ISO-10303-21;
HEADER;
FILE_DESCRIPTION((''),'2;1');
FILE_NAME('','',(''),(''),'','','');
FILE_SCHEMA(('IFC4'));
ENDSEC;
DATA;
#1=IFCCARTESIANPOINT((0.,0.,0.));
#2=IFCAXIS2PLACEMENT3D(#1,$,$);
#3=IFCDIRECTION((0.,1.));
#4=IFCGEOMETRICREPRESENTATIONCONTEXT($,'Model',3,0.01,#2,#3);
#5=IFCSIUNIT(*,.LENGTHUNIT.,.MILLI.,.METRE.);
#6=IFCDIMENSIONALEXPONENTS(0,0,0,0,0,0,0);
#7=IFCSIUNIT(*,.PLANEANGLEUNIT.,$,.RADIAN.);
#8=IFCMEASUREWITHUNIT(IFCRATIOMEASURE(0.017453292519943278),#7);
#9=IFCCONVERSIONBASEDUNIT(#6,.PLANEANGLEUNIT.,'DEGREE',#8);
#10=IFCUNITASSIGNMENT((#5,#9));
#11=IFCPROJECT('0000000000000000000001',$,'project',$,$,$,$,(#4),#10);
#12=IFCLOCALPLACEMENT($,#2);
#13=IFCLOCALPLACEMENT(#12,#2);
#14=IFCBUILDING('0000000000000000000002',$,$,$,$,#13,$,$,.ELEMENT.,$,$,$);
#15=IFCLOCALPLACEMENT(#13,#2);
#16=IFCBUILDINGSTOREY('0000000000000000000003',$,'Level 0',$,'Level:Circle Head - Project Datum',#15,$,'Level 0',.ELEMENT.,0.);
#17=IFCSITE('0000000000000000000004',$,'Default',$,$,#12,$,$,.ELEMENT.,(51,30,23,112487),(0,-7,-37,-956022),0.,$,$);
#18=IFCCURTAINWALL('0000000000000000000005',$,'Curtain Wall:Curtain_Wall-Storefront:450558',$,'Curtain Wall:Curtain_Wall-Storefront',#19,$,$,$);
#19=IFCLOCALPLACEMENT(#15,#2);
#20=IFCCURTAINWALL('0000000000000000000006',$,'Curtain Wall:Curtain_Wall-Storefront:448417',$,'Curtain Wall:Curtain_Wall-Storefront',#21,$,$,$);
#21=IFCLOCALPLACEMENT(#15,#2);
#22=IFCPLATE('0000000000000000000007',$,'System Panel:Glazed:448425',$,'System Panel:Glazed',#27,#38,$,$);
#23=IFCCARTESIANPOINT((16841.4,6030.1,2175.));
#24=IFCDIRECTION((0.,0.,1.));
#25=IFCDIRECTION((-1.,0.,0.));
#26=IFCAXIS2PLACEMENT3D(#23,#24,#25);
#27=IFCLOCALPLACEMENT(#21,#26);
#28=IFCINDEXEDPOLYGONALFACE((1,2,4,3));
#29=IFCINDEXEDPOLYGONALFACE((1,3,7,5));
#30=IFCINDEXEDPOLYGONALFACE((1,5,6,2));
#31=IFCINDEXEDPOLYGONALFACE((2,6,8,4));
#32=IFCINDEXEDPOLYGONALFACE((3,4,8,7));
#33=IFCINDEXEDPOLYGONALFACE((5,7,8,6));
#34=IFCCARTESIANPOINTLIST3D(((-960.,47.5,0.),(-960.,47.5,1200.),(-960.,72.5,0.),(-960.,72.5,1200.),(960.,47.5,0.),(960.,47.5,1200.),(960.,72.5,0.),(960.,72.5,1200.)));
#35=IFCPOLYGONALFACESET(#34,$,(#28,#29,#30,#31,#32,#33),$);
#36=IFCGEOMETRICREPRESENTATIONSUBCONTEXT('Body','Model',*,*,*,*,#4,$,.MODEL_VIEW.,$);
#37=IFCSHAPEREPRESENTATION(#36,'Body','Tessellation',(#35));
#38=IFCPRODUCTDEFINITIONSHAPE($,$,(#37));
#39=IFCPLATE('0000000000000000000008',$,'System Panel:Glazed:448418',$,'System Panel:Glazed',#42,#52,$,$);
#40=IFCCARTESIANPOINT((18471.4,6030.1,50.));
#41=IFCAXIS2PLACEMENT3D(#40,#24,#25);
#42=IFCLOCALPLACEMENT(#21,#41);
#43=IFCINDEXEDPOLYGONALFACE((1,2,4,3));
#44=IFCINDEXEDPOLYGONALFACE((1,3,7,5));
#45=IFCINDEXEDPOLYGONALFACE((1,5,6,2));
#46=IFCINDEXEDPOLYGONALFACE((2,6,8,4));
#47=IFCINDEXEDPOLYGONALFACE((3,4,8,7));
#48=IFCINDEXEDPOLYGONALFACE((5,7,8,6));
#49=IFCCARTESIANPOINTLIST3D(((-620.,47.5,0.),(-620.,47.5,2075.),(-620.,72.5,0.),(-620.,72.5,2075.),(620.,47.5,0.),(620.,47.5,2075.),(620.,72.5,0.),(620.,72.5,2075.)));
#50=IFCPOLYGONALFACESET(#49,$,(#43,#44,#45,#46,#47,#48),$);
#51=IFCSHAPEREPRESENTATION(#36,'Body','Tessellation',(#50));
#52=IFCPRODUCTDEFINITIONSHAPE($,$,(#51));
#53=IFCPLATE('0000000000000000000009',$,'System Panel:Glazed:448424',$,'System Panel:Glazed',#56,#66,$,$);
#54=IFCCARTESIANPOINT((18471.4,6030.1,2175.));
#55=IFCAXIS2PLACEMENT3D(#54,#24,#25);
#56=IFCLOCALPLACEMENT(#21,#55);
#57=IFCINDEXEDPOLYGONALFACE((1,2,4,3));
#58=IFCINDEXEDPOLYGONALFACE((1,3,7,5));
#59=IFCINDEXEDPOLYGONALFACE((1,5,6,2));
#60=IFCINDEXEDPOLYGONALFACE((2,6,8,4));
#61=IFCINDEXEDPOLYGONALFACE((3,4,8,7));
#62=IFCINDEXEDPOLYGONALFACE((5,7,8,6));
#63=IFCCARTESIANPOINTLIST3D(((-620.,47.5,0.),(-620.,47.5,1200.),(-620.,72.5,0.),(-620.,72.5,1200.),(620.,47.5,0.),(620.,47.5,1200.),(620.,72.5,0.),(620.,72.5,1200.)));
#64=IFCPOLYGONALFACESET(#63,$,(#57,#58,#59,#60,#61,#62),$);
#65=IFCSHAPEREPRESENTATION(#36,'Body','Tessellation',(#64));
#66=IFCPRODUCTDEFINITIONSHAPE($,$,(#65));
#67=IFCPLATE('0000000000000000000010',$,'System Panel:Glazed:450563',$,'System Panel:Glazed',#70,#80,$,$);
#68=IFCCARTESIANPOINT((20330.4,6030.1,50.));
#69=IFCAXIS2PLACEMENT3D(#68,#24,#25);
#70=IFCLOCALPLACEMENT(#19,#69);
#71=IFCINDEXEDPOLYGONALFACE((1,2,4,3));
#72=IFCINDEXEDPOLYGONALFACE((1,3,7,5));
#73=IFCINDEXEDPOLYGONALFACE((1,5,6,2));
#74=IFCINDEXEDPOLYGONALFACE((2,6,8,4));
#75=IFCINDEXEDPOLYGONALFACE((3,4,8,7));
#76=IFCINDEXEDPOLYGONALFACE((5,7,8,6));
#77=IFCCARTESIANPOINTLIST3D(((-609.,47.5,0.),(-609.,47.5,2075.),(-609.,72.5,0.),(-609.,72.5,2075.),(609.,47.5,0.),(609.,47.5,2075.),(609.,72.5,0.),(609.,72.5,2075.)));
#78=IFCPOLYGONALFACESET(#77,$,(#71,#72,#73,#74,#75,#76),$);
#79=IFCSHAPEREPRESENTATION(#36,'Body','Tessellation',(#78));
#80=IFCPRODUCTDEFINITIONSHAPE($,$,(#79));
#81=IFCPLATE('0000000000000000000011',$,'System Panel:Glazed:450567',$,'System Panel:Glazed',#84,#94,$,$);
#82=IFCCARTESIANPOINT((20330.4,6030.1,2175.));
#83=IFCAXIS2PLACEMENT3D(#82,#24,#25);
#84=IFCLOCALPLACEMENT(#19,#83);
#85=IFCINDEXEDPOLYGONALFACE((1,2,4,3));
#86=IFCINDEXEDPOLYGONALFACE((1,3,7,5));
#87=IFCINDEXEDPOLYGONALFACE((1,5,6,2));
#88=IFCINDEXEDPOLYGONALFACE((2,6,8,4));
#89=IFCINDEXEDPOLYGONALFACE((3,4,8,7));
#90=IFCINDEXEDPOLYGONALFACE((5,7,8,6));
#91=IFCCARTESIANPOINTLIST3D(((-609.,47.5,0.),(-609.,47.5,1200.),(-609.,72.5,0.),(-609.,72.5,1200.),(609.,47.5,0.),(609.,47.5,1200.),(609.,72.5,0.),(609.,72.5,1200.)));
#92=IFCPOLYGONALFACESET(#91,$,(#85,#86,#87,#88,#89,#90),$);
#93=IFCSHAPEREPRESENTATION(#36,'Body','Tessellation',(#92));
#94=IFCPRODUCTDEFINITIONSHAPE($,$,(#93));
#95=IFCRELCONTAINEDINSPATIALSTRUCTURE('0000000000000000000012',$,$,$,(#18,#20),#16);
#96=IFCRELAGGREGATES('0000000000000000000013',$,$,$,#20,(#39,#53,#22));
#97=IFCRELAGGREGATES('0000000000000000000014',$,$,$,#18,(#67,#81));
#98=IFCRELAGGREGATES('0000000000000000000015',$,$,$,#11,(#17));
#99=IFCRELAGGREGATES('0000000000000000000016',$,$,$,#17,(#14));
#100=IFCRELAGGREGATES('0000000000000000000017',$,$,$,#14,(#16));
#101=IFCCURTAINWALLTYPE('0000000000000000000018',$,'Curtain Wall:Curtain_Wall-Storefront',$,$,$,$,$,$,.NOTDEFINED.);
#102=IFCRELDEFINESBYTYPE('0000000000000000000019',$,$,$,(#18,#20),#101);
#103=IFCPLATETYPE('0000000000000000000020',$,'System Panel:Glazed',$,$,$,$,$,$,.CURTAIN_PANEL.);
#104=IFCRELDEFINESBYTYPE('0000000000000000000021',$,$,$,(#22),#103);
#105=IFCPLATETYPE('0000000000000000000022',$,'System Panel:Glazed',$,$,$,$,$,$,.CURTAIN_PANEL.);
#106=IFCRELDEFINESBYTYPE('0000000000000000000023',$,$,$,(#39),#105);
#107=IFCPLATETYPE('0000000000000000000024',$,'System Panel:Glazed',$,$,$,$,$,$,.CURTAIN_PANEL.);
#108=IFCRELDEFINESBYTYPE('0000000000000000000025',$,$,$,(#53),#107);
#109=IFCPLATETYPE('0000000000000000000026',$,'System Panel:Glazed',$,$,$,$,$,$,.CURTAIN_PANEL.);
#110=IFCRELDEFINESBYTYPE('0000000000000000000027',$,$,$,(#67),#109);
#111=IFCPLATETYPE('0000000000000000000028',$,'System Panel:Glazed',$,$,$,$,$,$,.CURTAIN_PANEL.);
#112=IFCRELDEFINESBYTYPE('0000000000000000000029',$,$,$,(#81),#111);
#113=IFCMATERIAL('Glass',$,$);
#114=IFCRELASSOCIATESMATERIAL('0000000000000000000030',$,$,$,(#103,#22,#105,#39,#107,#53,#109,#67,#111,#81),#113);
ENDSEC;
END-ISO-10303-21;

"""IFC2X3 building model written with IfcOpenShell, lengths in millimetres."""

from ifc_helpers import new_model, entity, si_unit, converted_unit, direction, frame, origin, origin_2d_with_axis, place, context, subcontext, project, spatial, rectangle, extrude, source, transform, mapped, material, type_object, type_shapes, element, aggregate, save


model = new_model("IFC2X3")

# Units and contexts
model_context = context("Model", 3, precision=0.01, world=origin(), true_north=direction((0.0, 1.0)))
body_context = subcontext(model_context, "Body", "Model", "MODEL_VIEW")
ifc_project = project(units=[si_unit("LENGTHUNIT", "METRE", prefix="MILLI"), converted_unit("PLANEANGLEUNIT", "DEGREE", entity("IfcRatioMeasure", 0.017453292519943278), si_unit("PLANEANGLEUNIT", "RADIAN"), dimensions=[0, 0, 0, 0, 0, 0, 0])], contexts=[model_context])

# Site, building, storey
site_placement = place(None, origin())
site = spatial("IfcSite", under=ifc_project, at=site_placement, Name="Default", CompositionType="ELEMENT", RefLatitude=(51, 30, 23, 112487), RefLongitude=(0, -7, -37, -956022), RefElevation=0.0)
building_placement = place(site_placement, origin())
building = spatial("IfcBuilding", under=site, at=building_placement, CompositionType="ELEMENT")
storey_placement = place(building_placement, origin())
storey = spatial("IfcBuildingStorey", under=building, at=storey_placement, Name="Level 0", ObjectType="Level:Circle Head - Project Datum", LongName="Level 0", CompositionType="ELEMENT", Elevation=0.0)

# Curtain walls
curtain_wall_type = type_object("IfcCurtainWallType", Name="Curtain Wall:Curtain_Wall-Storefront", PredefinedType="NOTDEFINED")
curtain_wall_1_placement = place(storey_placement, origin())
curtain_wall_1 = element("IfcCurtainWall", 1, at=curtain_wall_1_placement, inside=storey, type_object=curtain_wall_type, Name="Curtain Wall:Curtain_Wall-Storefront:450558", ObjectType="Curtain Wall:Curtain_Wall-Storefront")
curtain_wall_2_placement = place(storey_placement, origin())
curtain_wall_2 = element("IfcCurtainWall", 2, at=curtain_wall_2_placement, inside=storey, type_object=curtain_wall_type, Name="Curtain Wall:Curtain_Wall-Storefront:448417", ObjectType="Curtain Wall:Curtain_Wall-Storefront")

# Plates
ifc_material_1 = material(Name="Glass")
plate_type_1 = type_object("IfcPlateType", Name="System Panel:Glazed", PredefinedType="CURTAIN_PANEL", material=ifc_material_1)
shared_shape_1 = source(origin(), body_context, "Body", "SweptSolid", [
    extrude(rectangle(XDim=25.0, YDim=1920.0, at=origin_2d_with_axis()), frame((0.0, 60.0, 0.0), z_axis=(0.0, 0.0, 1.0), x_axis=(0.0, 1.0, 0.0)), (0.0, 0.0, 1.0), 1200.0),
])
type_shapes(plate_type_1, [shared_shape_1])
plate_1_placement = place(curtain_wall_2_placement, frame((16841.4, 6030.1, 2175.0), z_axis=(0.0, 0.0, 1.0), x_axis=(-1.0, 0.0, 0.0)))
plate_1 = element("IfcPlate", 3, at=plate_1_placement, type_object=plate_type_1, material=ifc_material_1, Name="System Panel:Glazed:448425", ObjectType="System Panel:Glazed", context=body_context, shape_type="MappedRepresentation", body=[
    mapped(shared_shape_1, transform((0.0, 0.0, 0.0), scale=1.0)),
])
plate_type_2 = type_object("IfcPlateType", Name="System Panel:Glazed", PredefinedType="CURTAIN_PANEL", material=ifc_material_1)
shared_shape_2 = source(origin(), body_context, "Body", "SweptSolid", [
    extrude(rectangle(XDim=25.0, YDim=1240.0, at=origin_2d_with_axis()), frame((0.0, 60.0, 0.0), z_axis=(0.0, 0.0, 1.0), x_axis=(0.0, 1.0, 0.0)), (0.0, 0.0, 1.0), 2075.0),
])
type_shapes(plate_type_2, [shared_shape_2])
plate_2_placement = place(curtain_wall_2_placement, frame((18471.4, 6030.1, 50.0), z_axis=(0.0, 0.0, 1.0), x_axis=(-1.0, 0.0, 0.0)))
plate_2 = element("IfcPlate", 4, at=plate_2_placement, type_object=plate_type_2, material=ifc_material_1, Name="System Panel:Glazed:448418", ObjectType="System Panel:Glazed", context=body_context, shape_type="MappedRepresentation", body=[
    mapped(shared_shape_2, transform((0.0, 0.0, 0.0), scale=1.0)),
])
plate_type_3 = type_object("IfcPlateType", Name="System Panel:Glazed", PredefinedType="CURTAIN_PANEL", material=ifc_material_1)
shared_shape_3 = source(origin(), body_context, "Body", "SweptSolid", [
    extrude(rectangle(XDim=25.0, YDim=1240.0, at=origin_2d_with_axis()), frame((0.0, 60.0, 0.0), z_axis=(0.0, 0.0, 1.0), x_axis=(0.0, 1.0, 0.0)), (0.0, 0.0, 1.0), 1200.0),
])
type_shapes(plate_type_3, [shared_shape_3])
plate_3_placement = place(curtain_wall_2_placement, frame((18471.4, 6030.1, 2175.0), z_axis=(0.0, 0.0, 1.0), x_axis=(-1.0, 0.0, 0.0)))
plate_3 = element("IfcPlate", 5, at=plate_3_placement, type_object=plate_type_3, material=ifc_material_1, Name="System Panel:Glazed:448424", ObjectType="System Panel:Glazed", context=body_context, shape_type="MappedRepresentation", body=[
    mapped(shared_shape_3, transform((0.0, 0.0, 0.0), scale=1.0)),
])
aggregate(curtain_wall_2, [plate_2, plate_3, plate_1])
plate_type_4 = type_object("IfcPlateType", Name="System Panel:Glazed", PredefinedType="CURTAIN_PANEL", material=ifc_material_1)
shared_shape_4 = source(origin(), body_context, "Body", "SweptSolid", [
    extrude(rectangle(XDim=25.0, YDim=1218.0, at=origin_2d_with_axis()), frame((0.0, 60.0, 0.0), z_axis=(0.0, 0.0, 1.0), x_axis=(0.0, 1.0, 0.0)), (0.0, 0.0, 1.0), 2075.0),
])
type_shapes(plate_type_4, [shared_shape_4])
plate_4_placement = place(curtain_wall_1_placement, frame((20330.4, 6030.1, 50.0), z_axis=(0.0, 0.0, 1.0), x_axis=(-1.0, 0.0, 0.0)))
plate_4 = element("IfcPlate", 6, at=plate_4_placement, type_object=plate_type_4, material=ifc_material_1, Name="System Panel:Glazed:450563", ObjectType="System Panel:Glazed", context=body_context, shape_type="MappedRepresentation", body=[
    mapped(shared_shape_4, transform((0.0, 0.0, 0.0), scale=1.0)),
])
plate_type_5 = type_object("IfcPlateType", Name="System Panel:Glazed", PredefinedType="CURTAIN_PANEL", material=ifc_material_1)
shared_shape_5 = source(origin(), body_context, "Body", "SweptSolid", [
    extrude(rectangle(XDim=25.0, YDim=1218.0, at=origin_2d_with_axis()), frame((0.0, 60.0, 0.0), z_axis=(0.0, 0.0, 1.0), x_axis=(0.0, 1.0, 0.0)), (0.0, 0.0, 1.0), 1200.0),
])
type_shapes(plate_type_5, [shared_shape_5])
plate_5_placement = place(curtain_wall_1_placement, frame((20330.4, 6030.1, 2175.0), z_axis=(0.0, 0.0, 1.0), x_axis=(-1.0, 0.0, 0.0)))
plate_5 = element("IfcPlate", 7, at=plate_5_placement, type_object=plate_type_5, material=ifc_material_1, Name="System Panel:Glazed:450567", ObjectType="System Panel:Glazed", context=body_context, shape_type="MappedRepresentation", body=[
    mapped(shared_shape_5, transform((0.0, 0.0, 0.0), scale=1.0)),
])
aggregate(curtain_wall_1, [plate_4, plate_5])

save(model, "model.ifc")
